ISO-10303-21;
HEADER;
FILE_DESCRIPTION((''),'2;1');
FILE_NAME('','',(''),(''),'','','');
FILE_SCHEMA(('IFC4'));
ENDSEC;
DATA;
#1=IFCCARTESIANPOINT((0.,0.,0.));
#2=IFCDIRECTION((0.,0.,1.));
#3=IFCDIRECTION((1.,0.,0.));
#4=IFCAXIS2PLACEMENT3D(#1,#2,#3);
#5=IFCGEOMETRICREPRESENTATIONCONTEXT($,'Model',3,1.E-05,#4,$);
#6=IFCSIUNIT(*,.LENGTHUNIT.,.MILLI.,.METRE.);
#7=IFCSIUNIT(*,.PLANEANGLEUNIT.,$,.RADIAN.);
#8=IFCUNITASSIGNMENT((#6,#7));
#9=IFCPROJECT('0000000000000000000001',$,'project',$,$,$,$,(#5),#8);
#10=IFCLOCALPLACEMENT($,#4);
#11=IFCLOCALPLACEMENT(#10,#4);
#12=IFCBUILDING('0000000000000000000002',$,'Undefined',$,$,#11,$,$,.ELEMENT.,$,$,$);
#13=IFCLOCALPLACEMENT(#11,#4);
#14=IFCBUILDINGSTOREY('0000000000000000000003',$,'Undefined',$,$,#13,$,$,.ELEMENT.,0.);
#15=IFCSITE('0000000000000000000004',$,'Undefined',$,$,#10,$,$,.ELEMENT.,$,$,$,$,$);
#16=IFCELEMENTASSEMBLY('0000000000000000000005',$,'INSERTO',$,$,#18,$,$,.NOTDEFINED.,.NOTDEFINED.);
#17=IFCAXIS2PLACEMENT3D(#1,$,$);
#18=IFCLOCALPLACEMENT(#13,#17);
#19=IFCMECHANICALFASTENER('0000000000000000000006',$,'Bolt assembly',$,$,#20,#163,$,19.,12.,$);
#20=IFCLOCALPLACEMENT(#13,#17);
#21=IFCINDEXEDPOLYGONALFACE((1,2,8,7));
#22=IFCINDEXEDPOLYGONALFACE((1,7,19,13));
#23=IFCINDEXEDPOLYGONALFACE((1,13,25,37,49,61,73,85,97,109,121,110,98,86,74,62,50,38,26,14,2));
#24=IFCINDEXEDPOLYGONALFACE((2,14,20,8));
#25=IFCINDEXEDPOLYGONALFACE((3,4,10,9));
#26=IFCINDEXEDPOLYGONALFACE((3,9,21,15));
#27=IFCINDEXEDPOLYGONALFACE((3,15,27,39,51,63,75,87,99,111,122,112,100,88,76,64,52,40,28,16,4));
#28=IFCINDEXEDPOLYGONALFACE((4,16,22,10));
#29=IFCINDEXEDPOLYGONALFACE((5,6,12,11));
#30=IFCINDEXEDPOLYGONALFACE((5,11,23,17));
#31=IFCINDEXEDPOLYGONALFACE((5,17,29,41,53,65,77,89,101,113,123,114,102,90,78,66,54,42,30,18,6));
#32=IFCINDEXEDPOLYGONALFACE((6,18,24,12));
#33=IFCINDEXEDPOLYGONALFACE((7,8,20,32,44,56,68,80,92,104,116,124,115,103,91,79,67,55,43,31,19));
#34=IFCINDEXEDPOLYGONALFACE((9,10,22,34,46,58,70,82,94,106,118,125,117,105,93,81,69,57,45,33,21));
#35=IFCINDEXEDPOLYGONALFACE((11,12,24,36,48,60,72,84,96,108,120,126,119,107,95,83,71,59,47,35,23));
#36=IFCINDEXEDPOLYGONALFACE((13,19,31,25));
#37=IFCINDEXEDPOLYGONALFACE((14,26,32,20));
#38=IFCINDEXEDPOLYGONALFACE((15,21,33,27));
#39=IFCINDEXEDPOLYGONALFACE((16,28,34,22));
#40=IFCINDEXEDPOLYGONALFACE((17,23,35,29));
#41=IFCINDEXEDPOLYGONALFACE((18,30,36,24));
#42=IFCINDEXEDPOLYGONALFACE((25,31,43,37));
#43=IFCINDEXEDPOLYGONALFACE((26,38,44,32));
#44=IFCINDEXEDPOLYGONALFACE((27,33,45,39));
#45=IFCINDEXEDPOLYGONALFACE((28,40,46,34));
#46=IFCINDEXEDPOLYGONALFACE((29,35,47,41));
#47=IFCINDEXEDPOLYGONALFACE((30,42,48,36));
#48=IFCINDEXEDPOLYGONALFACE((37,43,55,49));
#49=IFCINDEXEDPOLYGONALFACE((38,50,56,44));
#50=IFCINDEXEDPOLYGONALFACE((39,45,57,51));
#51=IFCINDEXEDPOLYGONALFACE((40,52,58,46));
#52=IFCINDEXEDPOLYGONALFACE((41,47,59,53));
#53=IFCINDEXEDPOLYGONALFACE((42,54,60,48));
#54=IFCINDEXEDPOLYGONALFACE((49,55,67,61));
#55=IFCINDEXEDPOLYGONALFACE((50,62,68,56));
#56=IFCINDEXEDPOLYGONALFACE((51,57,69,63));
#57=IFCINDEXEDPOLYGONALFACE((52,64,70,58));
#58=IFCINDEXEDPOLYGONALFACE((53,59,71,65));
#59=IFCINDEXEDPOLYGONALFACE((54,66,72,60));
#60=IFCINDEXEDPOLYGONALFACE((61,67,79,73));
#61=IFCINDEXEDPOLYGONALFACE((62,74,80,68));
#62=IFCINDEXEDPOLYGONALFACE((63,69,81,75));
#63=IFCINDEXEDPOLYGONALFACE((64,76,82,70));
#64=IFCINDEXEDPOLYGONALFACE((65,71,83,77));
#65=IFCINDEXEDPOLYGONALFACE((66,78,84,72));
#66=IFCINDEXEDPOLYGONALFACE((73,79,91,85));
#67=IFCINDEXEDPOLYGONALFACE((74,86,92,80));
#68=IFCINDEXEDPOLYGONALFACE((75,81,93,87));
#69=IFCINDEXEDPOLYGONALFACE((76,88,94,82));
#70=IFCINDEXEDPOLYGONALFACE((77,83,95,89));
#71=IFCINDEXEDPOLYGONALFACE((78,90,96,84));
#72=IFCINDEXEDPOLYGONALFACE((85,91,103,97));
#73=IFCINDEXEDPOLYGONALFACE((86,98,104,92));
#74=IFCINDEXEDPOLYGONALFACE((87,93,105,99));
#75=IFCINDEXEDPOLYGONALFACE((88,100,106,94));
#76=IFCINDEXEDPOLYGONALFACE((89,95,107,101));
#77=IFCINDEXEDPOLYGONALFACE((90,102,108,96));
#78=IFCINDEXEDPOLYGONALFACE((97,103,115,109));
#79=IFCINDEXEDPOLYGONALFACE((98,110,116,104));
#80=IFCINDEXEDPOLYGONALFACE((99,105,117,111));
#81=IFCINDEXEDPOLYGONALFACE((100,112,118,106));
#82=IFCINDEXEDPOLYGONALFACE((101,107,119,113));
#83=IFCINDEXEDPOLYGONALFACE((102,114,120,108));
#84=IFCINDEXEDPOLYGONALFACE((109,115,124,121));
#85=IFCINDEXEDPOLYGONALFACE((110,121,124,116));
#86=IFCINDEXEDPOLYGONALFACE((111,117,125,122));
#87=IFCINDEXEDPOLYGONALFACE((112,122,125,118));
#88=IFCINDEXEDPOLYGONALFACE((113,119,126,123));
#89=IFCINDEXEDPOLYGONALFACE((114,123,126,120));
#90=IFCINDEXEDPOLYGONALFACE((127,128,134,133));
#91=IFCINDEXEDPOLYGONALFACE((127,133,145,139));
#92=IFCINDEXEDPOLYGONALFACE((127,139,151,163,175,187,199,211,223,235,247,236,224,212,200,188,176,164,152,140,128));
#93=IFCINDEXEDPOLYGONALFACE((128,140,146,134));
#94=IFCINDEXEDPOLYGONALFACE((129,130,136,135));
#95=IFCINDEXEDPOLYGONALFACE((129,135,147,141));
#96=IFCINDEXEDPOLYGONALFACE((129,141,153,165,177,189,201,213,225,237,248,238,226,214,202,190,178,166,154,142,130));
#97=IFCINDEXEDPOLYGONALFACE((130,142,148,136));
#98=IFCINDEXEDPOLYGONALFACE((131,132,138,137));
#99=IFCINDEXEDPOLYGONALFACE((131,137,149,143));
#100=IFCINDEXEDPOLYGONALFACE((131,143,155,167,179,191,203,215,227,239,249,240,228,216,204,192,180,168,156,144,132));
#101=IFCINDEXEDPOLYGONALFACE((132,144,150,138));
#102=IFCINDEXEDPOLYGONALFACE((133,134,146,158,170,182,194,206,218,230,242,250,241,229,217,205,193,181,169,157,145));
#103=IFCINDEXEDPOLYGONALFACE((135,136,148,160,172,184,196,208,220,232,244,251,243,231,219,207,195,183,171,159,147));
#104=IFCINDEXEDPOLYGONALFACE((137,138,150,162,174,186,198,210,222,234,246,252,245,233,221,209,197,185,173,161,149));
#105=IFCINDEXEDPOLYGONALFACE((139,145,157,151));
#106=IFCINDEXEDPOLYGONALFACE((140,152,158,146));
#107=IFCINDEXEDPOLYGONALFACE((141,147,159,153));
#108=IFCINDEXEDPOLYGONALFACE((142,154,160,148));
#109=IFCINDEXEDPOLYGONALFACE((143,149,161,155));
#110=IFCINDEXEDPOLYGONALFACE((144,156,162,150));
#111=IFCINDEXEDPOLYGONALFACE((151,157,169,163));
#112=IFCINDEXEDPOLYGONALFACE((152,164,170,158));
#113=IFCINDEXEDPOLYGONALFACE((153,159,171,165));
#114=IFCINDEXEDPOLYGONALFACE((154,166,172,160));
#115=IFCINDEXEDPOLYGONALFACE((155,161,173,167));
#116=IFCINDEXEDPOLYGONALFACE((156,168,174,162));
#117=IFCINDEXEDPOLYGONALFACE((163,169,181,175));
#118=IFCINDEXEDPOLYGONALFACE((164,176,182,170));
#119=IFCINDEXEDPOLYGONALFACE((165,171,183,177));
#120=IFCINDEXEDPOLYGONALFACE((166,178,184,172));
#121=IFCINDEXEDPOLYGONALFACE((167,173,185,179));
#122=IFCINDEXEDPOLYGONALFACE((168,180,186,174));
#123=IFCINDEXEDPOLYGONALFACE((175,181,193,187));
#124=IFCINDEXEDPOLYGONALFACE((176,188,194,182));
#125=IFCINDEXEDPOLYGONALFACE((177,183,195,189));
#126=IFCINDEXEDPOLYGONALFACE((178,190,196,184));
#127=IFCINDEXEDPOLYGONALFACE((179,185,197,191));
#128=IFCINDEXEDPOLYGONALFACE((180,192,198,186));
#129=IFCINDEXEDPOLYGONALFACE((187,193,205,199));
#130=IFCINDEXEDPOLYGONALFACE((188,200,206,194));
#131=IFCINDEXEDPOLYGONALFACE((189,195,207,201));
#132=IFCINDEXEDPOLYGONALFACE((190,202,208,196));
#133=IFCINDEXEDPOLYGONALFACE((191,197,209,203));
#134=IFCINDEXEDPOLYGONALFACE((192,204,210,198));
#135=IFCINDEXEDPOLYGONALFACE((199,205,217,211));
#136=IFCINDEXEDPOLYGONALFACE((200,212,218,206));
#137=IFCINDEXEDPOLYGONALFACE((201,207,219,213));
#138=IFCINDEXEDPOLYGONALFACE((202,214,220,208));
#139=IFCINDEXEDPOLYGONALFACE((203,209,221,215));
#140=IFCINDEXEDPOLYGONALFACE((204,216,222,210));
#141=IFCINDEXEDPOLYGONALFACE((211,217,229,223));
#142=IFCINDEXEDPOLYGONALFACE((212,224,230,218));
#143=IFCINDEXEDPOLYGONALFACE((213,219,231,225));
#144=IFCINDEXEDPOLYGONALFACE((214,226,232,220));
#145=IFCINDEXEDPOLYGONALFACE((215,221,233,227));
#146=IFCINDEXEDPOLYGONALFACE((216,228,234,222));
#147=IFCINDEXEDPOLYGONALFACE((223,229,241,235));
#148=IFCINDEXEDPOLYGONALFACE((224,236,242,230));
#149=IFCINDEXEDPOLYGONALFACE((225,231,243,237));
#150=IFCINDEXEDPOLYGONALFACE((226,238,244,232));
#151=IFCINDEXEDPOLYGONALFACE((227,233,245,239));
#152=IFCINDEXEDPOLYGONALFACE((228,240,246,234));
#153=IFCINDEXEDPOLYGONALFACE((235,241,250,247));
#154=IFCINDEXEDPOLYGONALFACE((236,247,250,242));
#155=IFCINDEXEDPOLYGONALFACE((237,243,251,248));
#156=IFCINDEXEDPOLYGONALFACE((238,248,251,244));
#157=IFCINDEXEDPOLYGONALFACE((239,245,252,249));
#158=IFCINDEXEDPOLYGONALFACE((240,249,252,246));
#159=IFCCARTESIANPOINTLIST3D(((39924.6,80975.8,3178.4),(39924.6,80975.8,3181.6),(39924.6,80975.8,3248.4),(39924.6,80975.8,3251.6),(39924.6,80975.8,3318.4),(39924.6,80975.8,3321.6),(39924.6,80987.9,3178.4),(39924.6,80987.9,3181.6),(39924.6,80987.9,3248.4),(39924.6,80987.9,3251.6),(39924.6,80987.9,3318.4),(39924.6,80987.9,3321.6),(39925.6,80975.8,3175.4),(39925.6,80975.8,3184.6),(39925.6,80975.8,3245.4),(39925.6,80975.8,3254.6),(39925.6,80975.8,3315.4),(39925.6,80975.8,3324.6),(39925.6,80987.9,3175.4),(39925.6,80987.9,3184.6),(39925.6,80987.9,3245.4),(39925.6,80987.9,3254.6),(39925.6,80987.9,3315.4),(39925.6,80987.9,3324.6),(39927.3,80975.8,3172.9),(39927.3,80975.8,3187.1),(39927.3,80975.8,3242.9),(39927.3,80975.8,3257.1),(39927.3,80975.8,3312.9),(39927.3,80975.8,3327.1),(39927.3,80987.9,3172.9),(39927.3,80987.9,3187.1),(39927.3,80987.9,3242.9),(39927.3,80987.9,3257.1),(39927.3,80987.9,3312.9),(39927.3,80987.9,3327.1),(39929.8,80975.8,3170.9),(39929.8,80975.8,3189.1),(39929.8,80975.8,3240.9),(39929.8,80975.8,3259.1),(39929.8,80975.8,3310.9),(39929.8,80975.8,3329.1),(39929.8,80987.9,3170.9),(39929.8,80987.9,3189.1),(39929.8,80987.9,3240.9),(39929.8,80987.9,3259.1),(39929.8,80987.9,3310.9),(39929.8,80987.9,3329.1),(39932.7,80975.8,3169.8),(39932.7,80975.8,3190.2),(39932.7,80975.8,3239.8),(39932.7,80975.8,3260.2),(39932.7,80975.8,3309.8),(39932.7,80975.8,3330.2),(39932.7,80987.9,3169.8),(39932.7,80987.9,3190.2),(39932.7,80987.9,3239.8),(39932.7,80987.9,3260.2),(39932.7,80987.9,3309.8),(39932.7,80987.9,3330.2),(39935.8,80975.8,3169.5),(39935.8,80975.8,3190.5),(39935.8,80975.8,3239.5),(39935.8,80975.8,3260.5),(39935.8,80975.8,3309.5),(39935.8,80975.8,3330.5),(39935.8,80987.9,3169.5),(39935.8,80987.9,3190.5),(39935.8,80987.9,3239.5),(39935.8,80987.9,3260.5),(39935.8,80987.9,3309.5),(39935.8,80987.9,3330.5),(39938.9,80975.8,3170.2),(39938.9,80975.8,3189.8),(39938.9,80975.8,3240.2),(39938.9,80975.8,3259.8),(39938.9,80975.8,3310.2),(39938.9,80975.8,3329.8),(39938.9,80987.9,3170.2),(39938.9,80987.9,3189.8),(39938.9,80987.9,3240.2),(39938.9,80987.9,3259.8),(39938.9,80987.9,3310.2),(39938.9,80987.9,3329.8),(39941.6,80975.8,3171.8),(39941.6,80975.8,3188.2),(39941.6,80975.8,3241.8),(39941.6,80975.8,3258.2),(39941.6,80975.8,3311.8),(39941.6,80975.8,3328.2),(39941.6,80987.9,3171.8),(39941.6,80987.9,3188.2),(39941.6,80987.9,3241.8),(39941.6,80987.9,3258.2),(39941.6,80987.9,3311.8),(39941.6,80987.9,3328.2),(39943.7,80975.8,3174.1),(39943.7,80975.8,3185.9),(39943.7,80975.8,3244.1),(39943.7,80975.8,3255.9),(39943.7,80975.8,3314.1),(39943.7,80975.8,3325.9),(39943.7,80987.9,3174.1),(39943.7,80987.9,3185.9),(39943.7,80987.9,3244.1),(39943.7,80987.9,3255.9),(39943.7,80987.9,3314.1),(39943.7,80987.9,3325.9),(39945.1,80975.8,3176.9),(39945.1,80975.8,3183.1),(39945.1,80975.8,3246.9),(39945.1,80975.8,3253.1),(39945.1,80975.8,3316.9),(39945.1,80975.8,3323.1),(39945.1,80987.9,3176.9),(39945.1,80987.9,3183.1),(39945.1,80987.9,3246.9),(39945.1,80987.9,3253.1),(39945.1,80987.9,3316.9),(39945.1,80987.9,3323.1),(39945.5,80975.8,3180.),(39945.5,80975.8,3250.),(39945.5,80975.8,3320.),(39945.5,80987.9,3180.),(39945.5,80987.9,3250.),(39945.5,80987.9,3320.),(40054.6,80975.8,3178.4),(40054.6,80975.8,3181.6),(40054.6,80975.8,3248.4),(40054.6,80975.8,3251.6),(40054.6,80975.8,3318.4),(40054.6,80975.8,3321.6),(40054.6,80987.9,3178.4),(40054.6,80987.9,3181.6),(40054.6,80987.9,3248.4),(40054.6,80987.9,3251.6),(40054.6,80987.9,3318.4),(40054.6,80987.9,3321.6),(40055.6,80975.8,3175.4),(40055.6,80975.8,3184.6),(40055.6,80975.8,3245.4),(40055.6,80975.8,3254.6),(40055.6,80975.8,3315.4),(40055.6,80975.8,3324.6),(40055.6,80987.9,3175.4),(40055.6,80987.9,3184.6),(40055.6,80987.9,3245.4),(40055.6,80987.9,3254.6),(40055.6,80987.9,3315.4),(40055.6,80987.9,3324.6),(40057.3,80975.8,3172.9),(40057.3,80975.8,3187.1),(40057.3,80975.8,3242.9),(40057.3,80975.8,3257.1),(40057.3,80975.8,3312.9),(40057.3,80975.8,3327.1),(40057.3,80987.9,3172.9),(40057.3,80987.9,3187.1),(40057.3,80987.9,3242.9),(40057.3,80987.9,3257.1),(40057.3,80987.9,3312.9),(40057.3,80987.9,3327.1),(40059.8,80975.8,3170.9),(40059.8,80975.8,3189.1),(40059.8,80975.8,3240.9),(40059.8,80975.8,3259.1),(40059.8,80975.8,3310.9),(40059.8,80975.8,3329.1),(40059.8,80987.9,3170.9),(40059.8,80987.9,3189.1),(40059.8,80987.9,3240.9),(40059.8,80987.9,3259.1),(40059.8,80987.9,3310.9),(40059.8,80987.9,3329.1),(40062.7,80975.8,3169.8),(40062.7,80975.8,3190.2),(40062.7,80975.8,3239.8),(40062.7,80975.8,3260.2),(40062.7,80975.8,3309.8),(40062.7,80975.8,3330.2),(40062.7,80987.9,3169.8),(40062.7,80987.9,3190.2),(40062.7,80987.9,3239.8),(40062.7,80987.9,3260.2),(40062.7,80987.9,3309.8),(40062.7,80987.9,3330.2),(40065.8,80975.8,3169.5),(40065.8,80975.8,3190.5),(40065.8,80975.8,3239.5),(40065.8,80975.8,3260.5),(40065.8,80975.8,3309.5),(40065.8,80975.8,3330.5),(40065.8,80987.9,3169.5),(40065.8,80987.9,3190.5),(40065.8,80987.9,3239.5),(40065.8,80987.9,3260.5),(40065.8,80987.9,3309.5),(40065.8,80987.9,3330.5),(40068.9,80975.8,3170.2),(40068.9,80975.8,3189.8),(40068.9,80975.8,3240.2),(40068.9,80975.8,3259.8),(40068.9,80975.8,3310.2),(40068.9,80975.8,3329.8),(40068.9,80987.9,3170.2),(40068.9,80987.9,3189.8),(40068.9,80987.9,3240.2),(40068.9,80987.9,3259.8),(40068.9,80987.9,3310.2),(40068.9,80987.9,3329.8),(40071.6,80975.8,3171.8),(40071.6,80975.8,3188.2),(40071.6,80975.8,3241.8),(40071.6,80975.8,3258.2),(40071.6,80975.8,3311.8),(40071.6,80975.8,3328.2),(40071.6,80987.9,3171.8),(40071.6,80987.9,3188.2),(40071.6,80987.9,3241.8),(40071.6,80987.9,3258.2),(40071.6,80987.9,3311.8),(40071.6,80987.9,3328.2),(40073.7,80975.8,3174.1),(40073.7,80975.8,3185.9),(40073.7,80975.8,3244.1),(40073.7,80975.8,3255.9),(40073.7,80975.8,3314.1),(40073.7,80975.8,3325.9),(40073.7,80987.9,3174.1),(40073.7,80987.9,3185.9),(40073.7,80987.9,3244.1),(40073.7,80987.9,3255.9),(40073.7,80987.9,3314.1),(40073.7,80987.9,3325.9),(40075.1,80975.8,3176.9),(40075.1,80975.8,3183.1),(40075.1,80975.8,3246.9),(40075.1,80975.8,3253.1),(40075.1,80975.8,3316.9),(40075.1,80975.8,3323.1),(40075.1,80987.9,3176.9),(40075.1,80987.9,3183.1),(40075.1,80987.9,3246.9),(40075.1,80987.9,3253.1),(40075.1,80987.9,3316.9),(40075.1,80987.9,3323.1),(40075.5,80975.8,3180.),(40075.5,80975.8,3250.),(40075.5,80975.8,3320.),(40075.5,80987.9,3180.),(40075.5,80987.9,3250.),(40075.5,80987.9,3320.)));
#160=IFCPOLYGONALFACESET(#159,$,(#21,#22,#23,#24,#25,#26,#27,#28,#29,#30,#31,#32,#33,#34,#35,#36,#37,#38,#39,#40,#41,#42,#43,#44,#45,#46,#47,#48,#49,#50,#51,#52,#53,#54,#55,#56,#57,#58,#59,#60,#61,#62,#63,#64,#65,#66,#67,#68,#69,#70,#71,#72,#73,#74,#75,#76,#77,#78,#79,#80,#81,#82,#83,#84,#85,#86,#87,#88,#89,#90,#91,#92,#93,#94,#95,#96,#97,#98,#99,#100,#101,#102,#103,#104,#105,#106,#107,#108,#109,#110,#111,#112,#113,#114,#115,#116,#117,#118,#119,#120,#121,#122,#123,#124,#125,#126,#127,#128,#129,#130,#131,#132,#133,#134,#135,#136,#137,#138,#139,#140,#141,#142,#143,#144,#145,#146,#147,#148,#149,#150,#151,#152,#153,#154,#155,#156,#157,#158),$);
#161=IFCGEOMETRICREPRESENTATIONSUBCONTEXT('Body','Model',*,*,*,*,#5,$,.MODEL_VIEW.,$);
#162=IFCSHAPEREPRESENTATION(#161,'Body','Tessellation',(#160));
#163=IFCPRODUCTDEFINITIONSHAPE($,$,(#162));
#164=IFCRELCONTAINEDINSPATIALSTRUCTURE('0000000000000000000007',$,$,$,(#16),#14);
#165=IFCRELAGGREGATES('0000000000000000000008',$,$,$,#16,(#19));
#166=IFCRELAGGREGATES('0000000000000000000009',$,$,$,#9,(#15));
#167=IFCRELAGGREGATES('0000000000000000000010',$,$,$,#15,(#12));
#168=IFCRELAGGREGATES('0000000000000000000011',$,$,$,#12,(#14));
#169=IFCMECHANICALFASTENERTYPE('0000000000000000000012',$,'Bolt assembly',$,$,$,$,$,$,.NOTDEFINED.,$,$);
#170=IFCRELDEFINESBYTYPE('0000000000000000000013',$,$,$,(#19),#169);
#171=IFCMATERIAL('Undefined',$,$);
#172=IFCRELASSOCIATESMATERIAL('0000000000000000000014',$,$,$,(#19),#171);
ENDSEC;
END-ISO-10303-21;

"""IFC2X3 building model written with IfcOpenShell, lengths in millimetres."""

from ifc_helpers import new_model, si_unit, frame, origin_with_axes, origin_2d_with_axis, place, context, subcontext, project, spatial, circle, extrude, source, transform, mapped, material, type_object, element, aggregate, save


model = new_model("IFC2X3")

# Units and contexts
model_context = context("Model", 3, precision=1e-05, world=origin_with_axes())
body_context = subcontext(model_context, "Body", "Model", "MODEL_VIEW")
ifc_project = project(units=[si_unit("LENGTHUNIT", "METRE", prefix="MILLI"), si_unit("PLANEANGLEUNIT", "RADIAN")], contexts=[model_context])

# Site, building, storey
site_placement = place(None, origin_with_axes())
site = spatial("IfcSite", under=ifc_project, at=site_placement, Name="Undefined", CompositionType="ELEMENT")
building_placement = place(site_placement, origin_with_axes())
building = spatial("IfcBuilding", under=site, at=building_placement, Name="Undefined", CompositionType="ELEMENT")
storey_placement = place(building_placement, origin_with_axes())
storey = spatial("IfcBuildingStorey", under=building, at=storey_placement, Name="Undefined", CompositionType="ELEMENT", Elevation=0.0)

# Element assembly
assembly_1_placement = place(storey_placement, origin_with_axes())
assembly_1 = element("IfcElementAssembly", 1, at=assembly_1_placement, inside=storey, Name="INSERTO", AssemblyPlace="NOTDEFINED", PredefinedType="NOTDEFINED")

# Shared definitions
ifc_material_1 = material(Name="Undefined")
mechanical_fastener_type = type_object("IfcMechanicalFastenerType", Name="Bolt assembly")

# Mechanical fastener
shared_shape_1 = source(origin_with_axes(), body_context, "Body", "SweptSolid", [
    extrude(circle(Radius=10.5, at=origin_2d_with_axis()), frame((0.0, 0.0, 0.0), z_axis=(0.0, 1.0, 0.0), x_axis=(1.0, 0.0, 0.0)), (0.0, 0.0, 1.0), 12.1),
])
mechanical_fastener_1_placement = place(assembly_1_placement, frame((39935.0, 80987.9, 3250.0), z_axis=(-0.000002, 0.0, -1.0), x_axis=(1.0, -0.000012, -0.000002)))
mechanical_fastener_1 = element("IfcMechanicalFastener", 2, at=mechanical_fastener_1_placement, type_object=mechanical_fastener_type, material=ifc_material_1, Name="Bolt assembly", NominalDiameter=19.0, NominalLength=12.0, context=body_context, shape_type="MappedRepresentation", body=[
    mapped(shared_shape_1, transform((0.0, 0.0, -70.0))),
    mapped(shared_shape_1, transform((130.0, 0.0, -70.0))),
    mapped(shared_shape_1, transform((0.0, 0.0, 0.0))),
    mapped(shared_shape_1, transform((130.0, 0.0, 0.0))),
    mapped(shared_shape_1, transform((0.0, 0.0, 70.0))),
    mapped(shared_shape_1, transform((130.0, 0.0, 70.0))),
])
aggregate(assembly_1, [mechanical_fastener_1])

save(model, "model.ifc")
